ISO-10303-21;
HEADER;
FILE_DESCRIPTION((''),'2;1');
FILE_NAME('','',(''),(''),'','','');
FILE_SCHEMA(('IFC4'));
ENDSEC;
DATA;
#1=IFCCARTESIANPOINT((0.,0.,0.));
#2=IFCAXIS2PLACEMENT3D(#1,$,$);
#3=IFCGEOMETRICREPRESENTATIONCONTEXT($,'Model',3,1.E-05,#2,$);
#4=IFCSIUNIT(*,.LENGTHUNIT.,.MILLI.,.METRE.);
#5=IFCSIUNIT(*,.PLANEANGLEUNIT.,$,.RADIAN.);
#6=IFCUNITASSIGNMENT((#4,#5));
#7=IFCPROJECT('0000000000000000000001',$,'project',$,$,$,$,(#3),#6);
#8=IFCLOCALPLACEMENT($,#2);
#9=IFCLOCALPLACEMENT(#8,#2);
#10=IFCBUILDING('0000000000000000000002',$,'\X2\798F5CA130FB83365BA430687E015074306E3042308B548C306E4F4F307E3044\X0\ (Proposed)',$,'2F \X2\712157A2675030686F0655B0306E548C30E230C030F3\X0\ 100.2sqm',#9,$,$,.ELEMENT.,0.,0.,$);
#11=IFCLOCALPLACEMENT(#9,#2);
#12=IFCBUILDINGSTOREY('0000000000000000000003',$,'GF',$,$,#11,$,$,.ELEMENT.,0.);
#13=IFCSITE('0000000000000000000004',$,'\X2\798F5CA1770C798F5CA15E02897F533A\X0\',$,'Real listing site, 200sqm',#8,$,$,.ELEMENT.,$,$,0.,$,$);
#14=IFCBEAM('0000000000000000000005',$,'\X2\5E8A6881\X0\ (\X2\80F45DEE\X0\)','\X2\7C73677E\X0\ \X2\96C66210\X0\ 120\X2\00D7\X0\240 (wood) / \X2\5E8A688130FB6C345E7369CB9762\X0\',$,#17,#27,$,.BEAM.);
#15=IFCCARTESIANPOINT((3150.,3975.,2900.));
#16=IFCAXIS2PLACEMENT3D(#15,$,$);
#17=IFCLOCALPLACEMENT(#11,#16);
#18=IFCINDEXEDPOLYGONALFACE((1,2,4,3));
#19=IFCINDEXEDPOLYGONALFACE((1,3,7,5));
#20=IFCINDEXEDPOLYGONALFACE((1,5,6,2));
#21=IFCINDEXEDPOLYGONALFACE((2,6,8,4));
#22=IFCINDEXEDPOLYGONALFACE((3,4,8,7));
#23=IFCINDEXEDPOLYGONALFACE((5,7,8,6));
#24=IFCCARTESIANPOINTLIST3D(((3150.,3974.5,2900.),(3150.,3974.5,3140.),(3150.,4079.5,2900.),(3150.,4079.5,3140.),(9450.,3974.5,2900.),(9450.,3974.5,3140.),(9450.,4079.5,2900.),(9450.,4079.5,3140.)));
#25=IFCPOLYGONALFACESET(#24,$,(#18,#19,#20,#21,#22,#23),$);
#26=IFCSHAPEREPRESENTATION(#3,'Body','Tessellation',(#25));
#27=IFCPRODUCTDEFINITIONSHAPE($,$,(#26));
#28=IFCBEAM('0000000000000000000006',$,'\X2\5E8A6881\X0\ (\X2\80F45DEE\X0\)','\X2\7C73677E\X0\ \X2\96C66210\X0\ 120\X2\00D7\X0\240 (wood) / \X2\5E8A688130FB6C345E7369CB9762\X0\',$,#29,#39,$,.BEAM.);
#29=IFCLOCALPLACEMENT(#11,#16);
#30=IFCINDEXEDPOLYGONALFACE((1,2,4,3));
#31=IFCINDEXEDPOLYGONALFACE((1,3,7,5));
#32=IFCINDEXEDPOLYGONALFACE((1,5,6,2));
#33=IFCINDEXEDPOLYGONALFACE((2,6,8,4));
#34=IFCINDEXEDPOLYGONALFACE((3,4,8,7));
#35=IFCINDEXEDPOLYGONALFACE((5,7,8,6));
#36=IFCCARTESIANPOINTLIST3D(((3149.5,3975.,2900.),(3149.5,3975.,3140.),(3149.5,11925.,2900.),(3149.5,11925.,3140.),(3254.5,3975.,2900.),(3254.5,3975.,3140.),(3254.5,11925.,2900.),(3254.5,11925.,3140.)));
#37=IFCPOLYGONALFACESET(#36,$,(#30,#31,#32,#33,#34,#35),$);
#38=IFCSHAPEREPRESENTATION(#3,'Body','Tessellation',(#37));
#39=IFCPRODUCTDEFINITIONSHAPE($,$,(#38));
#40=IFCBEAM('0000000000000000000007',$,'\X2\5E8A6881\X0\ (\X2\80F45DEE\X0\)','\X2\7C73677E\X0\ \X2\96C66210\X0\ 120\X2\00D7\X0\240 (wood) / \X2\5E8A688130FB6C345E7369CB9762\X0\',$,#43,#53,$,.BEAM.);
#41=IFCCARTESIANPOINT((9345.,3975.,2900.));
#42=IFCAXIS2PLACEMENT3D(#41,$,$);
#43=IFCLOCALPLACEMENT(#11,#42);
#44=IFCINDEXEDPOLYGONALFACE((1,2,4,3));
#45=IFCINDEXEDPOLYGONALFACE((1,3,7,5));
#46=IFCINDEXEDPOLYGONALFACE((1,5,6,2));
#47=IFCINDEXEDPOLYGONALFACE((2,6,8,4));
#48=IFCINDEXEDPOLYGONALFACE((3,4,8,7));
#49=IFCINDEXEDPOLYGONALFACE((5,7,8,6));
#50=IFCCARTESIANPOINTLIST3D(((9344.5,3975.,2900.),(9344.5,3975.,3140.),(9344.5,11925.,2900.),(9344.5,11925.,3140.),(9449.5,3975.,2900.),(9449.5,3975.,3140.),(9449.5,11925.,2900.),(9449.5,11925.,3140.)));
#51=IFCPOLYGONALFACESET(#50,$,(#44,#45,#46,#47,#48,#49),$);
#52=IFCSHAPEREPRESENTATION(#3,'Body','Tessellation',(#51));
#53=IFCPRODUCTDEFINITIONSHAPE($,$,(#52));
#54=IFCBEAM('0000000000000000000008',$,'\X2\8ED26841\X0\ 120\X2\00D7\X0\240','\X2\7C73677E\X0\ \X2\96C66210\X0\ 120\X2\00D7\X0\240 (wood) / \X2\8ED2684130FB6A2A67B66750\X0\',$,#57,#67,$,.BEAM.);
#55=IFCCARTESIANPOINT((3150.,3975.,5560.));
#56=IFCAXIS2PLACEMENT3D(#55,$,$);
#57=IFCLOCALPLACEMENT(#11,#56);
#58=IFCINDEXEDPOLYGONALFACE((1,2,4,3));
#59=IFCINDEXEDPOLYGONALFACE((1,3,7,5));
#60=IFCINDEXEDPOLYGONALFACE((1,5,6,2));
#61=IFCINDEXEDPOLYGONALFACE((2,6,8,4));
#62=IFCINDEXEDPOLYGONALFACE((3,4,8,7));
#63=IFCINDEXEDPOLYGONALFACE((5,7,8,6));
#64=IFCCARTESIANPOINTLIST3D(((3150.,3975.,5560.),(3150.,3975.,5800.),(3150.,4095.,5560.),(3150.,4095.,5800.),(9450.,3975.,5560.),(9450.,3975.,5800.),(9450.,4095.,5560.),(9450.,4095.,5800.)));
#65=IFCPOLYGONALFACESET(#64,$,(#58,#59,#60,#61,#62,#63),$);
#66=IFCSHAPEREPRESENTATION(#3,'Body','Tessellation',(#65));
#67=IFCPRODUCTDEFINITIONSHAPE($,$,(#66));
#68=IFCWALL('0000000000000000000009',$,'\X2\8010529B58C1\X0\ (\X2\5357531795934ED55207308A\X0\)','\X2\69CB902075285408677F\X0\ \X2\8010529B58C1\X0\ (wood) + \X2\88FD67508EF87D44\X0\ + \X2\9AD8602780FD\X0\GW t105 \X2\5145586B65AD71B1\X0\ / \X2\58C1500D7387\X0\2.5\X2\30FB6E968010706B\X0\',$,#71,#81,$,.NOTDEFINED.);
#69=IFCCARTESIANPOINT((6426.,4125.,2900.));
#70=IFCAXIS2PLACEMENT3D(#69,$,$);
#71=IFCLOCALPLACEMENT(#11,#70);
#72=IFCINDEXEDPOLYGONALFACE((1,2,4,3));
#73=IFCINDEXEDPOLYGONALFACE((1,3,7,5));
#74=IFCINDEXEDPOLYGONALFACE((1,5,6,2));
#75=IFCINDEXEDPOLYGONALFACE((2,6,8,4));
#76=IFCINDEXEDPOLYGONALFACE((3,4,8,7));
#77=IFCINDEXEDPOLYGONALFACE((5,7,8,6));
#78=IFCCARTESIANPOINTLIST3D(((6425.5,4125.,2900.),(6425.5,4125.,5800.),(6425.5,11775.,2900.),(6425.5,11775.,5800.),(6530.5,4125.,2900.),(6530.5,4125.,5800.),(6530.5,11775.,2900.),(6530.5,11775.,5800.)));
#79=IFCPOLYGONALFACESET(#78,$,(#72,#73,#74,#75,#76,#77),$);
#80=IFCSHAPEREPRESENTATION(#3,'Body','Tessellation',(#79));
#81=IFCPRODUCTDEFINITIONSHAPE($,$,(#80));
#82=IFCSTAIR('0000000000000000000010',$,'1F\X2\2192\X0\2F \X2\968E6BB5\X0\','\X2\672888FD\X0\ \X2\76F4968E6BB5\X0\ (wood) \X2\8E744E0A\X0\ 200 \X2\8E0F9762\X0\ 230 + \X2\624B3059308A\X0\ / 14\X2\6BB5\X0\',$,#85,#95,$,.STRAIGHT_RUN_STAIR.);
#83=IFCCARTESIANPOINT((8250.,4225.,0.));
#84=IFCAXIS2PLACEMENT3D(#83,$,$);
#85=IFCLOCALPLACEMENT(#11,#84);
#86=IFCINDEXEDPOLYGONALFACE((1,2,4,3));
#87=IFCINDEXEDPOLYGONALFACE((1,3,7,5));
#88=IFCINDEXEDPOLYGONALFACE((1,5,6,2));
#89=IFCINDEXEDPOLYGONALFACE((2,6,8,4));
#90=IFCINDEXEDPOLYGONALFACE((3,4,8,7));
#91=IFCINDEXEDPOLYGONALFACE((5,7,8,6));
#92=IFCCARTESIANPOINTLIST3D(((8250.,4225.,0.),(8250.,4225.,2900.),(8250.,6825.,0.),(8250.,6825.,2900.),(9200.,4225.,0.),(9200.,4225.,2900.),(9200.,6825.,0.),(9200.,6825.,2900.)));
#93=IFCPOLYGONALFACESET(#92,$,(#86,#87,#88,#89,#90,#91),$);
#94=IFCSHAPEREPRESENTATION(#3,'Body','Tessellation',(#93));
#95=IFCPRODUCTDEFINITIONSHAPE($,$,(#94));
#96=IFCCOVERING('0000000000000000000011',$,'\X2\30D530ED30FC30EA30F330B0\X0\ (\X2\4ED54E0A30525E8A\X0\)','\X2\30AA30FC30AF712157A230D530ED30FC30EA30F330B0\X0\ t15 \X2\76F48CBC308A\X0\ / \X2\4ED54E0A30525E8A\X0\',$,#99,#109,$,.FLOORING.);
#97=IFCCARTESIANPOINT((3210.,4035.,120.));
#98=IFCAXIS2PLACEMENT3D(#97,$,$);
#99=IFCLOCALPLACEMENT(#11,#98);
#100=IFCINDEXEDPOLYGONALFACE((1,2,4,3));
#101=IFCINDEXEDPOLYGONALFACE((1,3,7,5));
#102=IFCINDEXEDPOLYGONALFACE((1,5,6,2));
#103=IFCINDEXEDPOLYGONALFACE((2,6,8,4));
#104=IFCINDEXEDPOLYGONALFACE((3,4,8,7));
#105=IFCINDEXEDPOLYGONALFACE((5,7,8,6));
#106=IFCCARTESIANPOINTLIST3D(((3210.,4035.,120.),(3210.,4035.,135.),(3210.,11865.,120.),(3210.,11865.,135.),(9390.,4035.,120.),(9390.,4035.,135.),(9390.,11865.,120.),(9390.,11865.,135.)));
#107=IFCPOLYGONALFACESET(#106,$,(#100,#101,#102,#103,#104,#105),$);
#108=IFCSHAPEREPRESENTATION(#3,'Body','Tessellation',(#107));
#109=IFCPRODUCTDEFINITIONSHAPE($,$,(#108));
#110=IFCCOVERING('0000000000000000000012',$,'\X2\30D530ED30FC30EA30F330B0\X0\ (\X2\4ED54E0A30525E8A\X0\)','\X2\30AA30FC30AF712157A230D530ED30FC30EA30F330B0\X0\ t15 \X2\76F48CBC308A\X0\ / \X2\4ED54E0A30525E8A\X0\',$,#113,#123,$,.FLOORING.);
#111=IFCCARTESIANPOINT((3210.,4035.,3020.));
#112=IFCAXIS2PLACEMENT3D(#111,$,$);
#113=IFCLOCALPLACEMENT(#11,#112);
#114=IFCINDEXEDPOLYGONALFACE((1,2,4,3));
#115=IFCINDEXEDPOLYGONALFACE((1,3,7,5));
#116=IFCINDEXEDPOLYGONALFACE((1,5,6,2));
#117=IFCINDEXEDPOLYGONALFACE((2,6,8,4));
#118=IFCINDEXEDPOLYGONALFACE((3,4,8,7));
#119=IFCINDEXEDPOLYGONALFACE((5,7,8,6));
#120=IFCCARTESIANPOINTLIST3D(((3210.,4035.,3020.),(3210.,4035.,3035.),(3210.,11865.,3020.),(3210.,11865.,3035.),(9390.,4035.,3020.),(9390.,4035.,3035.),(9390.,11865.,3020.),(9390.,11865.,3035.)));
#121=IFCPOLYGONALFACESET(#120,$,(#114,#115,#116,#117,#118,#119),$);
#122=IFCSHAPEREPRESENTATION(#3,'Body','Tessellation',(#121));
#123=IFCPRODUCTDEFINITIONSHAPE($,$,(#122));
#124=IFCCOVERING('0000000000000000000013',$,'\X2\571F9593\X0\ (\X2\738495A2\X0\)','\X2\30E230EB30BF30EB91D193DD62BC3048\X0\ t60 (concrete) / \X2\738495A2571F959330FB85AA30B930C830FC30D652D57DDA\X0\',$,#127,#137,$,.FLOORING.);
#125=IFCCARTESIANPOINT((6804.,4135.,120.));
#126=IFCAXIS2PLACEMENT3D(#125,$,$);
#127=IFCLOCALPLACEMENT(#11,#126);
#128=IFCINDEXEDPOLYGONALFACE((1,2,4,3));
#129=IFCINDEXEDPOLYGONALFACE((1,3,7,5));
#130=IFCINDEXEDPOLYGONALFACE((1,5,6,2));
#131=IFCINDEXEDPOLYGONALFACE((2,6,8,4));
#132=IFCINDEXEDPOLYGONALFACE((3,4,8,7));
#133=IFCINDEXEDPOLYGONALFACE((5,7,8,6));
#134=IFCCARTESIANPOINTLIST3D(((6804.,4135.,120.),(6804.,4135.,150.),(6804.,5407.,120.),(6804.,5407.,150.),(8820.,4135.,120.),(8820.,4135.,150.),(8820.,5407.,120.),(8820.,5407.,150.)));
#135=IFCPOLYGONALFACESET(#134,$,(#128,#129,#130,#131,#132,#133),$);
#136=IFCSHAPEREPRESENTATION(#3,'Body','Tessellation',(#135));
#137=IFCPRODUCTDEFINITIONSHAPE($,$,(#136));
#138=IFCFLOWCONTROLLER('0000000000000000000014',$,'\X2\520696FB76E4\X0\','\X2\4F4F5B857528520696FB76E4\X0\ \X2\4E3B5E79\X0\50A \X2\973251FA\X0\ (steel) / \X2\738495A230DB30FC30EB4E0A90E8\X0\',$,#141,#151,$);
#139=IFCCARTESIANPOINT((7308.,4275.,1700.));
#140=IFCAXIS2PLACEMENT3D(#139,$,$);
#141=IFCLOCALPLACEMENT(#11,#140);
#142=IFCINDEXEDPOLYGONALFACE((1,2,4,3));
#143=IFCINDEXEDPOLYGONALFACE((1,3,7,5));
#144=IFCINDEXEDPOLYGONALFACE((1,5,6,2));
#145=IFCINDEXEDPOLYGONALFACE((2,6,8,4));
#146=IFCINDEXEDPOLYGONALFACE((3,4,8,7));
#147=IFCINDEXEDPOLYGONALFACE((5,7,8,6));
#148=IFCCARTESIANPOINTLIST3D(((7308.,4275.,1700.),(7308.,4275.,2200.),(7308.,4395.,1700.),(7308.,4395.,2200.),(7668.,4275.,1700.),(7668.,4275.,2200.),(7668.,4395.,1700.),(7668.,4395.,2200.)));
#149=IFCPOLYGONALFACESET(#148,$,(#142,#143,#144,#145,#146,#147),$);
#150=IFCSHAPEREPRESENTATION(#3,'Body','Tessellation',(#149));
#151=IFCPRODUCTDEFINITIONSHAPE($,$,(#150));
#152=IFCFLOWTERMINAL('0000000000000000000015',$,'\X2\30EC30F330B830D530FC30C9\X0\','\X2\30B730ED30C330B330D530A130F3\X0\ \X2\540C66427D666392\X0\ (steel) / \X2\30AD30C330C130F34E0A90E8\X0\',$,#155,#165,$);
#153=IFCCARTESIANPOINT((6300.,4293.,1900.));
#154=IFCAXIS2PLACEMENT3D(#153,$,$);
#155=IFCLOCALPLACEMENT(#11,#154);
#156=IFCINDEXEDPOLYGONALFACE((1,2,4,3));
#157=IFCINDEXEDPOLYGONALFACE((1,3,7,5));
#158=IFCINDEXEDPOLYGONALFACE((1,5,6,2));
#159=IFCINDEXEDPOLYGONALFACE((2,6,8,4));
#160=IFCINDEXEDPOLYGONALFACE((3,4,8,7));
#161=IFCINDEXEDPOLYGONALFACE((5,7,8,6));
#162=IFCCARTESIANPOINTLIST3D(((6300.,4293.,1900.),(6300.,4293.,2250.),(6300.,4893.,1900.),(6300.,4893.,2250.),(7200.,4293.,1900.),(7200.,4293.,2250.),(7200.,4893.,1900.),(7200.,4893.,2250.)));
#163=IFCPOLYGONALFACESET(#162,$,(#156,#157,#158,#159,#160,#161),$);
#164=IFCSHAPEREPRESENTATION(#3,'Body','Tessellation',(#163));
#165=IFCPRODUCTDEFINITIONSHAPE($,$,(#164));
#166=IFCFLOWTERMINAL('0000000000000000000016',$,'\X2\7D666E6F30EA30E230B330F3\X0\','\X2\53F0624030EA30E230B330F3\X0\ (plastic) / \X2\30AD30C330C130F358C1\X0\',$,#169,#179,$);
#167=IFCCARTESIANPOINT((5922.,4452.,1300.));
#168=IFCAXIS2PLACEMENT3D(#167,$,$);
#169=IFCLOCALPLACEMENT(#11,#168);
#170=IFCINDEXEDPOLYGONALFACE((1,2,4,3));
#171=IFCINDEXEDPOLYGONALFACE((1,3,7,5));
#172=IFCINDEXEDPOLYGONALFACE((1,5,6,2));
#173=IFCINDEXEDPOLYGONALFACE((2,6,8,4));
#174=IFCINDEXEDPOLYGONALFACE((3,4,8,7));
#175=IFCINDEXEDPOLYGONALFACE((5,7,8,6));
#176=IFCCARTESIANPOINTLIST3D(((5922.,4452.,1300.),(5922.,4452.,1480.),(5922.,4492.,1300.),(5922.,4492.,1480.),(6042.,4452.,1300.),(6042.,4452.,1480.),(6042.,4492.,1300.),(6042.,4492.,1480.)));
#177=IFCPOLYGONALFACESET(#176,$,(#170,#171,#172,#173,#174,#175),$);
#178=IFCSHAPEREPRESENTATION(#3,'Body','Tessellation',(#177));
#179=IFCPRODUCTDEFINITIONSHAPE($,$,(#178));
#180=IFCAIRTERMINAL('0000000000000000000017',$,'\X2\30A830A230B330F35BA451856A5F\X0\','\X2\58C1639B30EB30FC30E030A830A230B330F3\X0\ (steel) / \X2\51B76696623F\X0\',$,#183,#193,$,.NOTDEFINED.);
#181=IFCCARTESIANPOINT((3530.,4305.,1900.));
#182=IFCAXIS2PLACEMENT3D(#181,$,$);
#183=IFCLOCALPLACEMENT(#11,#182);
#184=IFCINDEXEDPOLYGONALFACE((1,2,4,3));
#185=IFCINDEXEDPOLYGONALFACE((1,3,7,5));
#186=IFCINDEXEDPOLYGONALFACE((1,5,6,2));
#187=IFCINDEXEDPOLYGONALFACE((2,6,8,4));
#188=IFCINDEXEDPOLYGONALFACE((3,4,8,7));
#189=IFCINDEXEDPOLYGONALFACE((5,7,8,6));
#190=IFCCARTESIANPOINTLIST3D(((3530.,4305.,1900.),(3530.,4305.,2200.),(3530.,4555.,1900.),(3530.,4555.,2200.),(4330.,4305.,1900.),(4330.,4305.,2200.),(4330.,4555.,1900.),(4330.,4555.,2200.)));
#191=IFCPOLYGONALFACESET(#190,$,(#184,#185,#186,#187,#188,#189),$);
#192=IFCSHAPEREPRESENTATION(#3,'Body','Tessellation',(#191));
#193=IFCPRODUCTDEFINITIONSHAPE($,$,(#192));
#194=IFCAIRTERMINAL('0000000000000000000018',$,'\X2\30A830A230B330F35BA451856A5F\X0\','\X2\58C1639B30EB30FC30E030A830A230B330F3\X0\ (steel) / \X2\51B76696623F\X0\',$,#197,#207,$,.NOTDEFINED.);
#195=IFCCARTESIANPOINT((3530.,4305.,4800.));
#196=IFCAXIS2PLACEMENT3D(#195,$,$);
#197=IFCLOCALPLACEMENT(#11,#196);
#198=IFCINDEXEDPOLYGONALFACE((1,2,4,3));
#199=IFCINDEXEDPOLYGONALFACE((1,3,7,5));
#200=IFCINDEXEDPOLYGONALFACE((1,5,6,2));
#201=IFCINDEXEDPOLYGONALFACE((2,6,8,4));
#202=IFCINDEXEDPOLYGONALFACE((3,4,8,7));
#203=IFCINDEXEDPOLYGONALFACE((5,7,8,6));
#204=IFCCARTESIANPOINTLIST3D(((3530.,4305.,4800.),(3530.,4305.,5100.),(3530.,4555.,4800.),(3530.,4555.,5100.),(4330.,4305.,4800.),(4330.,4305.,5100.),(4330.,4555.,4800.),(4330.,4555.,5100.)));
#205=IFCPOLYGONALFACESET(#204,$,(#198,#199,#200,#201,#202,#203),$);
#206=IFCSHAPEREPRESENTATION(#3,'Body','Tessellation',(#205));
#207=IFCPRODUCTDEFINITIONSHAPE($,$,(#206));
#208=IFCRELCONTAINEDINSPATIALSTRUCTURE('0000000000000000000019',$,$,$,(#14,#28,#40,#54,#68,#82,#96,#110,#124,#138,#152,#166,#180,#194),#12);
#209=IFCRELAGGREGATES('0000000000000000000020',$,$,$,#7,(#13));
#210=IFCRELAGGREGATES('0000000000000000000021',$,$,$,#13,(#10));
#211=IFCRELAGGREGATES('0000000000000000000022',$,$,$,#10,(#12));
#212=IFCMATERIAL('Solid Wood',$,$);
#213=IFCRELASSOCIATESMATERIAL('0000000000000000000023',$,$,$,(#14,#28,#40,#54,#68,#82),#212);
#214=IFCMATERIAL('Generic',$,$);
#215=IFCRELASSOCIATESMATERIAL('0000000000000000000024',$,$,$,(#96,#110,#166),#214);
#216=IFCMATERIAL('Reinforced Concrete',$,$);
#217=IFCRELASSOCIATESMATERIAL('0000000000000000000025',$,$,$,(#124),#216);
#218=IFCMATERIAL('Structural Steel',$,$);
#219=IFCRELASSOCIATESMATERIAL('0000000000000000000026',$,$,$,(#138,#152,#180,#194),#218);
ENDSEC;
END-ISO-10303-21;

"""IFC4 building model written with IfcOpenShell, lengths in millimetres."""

from ifc_helpers import new_model, si_unit, frame, frame_2d, origin, place, context, project, spatial, rectangle, extrude, material, element, save


model = new_model("IFC4")

# Units and contexts
model_context = context("Model", 3, precision=1e-05, world=origin())
ifc_project = project(units=[si_unit("LENGTHUNIT", "METRE", prefix="MILLI"), si_unit("PLANEANGLEUNIT", "RADIAN")], contexts=[model_context])

# Site, building, storey
site_placement = place(None, origin())
site = spatial("IfcSite", under=ifc_project, at=site_placement, Name="福岡県福岡市西区", ObjectType="Real listing site, 200sqm", CompositionType="ELEMENT", RefElevation=0.0)
building_placement = place(site_placement, origin())
building = spatial("IfcBuilding", under=site, at=building_placement, Name="福岡・茶室と縁側のある和の住まい (Proposed)", ObjectType="2F 無垢材と漆喰の和モダン 100.2sqm", CompositionType="ELEMENT", ElevationOfRefHeight=0.0, ElevationOfTerrain=0.0)
storey_placement = place(building_placement, origin())
storey = spatial("IfcBuildingStorey", under=building, at=storey_placement, Name="GF", CompositionType="ELEMENT", Elevation=0.0)

# Shared definitions
ifc_material_1 = material(Name="Solid Wood")

# Beams
beam_1_placement = place(storey_placement, frame((3150.0, 3975.0, 2900.0)))
element("IfcBeam", 1, at=beam_1_placement, inside=storey, material=ifc_material_1, Name="床梁 (胴差)", Description="米松 集成 120×240 (wood) / 床梁・水平構面", PredefinedType="BEAM", context=model_context, shape_type="SweptSolid", body=[
    extrude(rectangle(XDim=6300.0, YDim=105.0, at=frame_2d((3150.0, 52.0))), frame((3150.0, 3975.0, 2900.0)), (0.0, 0.0, 1.0), 240.0),
])
beam_2_placement = place(storey_placement, frame((3150.0, 3975.0, 2900.0)))
element("IfcBeam", 2, at=beam_2_placement, inside=storey, material=ifc_material_1, Name="床梁 (胴差)", Description="米松 集成 120×240 (wood) / 床梁・水平構面", PredefinedType="BEAM", context=model_context, shape_type="SweptSolid", body=[
    extrude(rectangle(XDim=105.0, YDim=7950.0, at=frame_2d((52.0, 3975.0))), frame((3150.0, 3975.0, 2900.0)), (0.0, 0.0, 1.0), 240.0),
])
beam_3_placement = place(storey_placement, frame((9345.0, 3975.0, 2900.0)))
element("IfcBeam", 3, at=beam_3_placement, inside=storey, material=ifc_material_1, Name="床梁 (胴差)", Description="米松 集成 120×240 (wood) / 床梁・水平構面", PredefinedType="BEAM", context=model_context, shape_type="SweptSolid", body=[
    extrude(rectangle(XDim=105.0, YDim=7950.0, at=frame_2d((52.0, 3975.0))), frame((9345.0, 3975.0, 2900.0)), (0.0, 0.0, 1.0), 240.0),
])
beam_4_placement = place(storey_placement, frame((3150.0, 3975.0, 5560.0)))
element("IfcBeam", 4, at=beam_4_placement, inside=storey, material=ifc_material_1, Name="軒桁 120×240", Description="米松 集成 120×240 (wood) / 軒桁・横架材", PredefinedType="BEAM", context=model_context, shape_type="SweptSolid", body=[
    extrude(rectangle(XDim=6300.0, YDim=120.0, at=frame_2d((3150.0, 60.0))), frame((3150.0, 3975.0, 5560.0)), (0.0, 0.0, 1.0), 240.0),
])

# Wall
wall_1_placement = place(storey_placement, frame((6426.0, 4125.0, 2900.0)))
element("IfcWall", 5, at=wall_1_placement, inside=storey, material=ifc_material_1, Name="耐力壁 (南北間仕切り)", Description="構造用合板 耐力壁 (wood) + 製材軸組 + 高性能GW t105 充填断熱 / 壁倍率2.5・準耐火", PredefinedType="NOTDEFINED", context=model_context, shape_type="SweptSolid", body=[
    extrude(rectangle(XDim=105.0, YDim=7650.0, at=frame_2d((52.0, 3825.0))), frame((6426.0, 4125.0, 2900.0)), (0.0, 0.0, 1.0), 2900.0),
])

# Stair
stair_placement = place(storey_placement, frame((8250.0, 4225.0, 0.0)))
element("IfcStair", 6, at=stair_placement, inside=storey, material=ifc_material_1, Name="1F→2F 階段", Description="木製 直階段 (wood) 蹴上 200 踏面 230 + 手すり / 14段", PredefinedType="STRAIGHT_RUN_STAIR", context=model_context, shape_type="SweptSolid", body=[
    extrude(rectangle(XDim=950.0, YDim=2600.0, at=frame_2d((475.0, 1300.0))), frame((8250.0, 4225.0, 0.0)), (0.0, 0.0, 1.0), 2900.0),
])

# Coverings
ifc_material_2 = material(Name="Generic")
covering_1_placement = place(storey_placement, frame((3210.0, 4035.0, 120.0)))
element("IfcCovering", 7, at=covering_1_placement, inside=storey, material=ifc_material_2, Name="フローリング (仕上げ床)", Description="オーク無垢フローリング t15 直貼り / 仕上げ床", PredefinedType="FLOORING", context=model_context, shape_type="SweptSolid", body=[
    extrude(rectangle(XDim=6180.0, YDim=7830.0, at=frame_2d((3090.0, 3915.0))), frame((3210.0, 4035.0, 120.0)), (0.0, 0.0, 1.0), 15.0),
])
covering_2_placement = place(storey_placement, frame((3210.0, 4035.0, 3020.0)))
element("IfcCovering", 8, at=covering_2_placement, inside=storey, material=ifc_material_2, Name="フローリング (仕上げ床)", Description="オーク無垢フローリング t15 直貼り / 仕上げ床", PredefinedType="FLOORING", context=model_context, shape_type="SweptSolid", body=[
    extrude(rectangle(XDim=6180.0, YDim=7830.0, at=frame_2d((3090.0, 3915.0))), frame((3210.0, 4035.0, 3020.0)), (0.0, 0.0, 1.0), 15.0),
])
ifc_material_3 = material(Name="Reinforced Concrete")
covering_3_placement = place(storey_placement, frame((6804.0, 4135.0, 120.0)))
element("IfcCovering", 9, at=covering_3_placement, inside=storey, material=ifc_material_3, Name="土間 (玄関)", Description="モルタル金鏝押え t60 (concrete) / 玄関土間・薪ストーブ動線", PredefinedType="FLOORING", context=model_context, shape_type="SweptSolid", body=[
    extrude(rectangle(XDim=2016.0, YDim=1272.0, at=frame_2d((1008.0, 636.0))), frame((6804.0, 4135.0, 120.0)), (0.0, 0.0, 1.0), 30.0),
])

# Flow controller
ifc_material_4 = material(Name="Structural Steel")
flow_controller_placement = place(storey_placement, frame((7308.0, 4275.0, 1700.0)))
element("IfcFlowController", 10, at=flow_controller_placement, inside=storey, material=ifc_material_4, Name="分電盤", Description="住宅用分電盤 主幹50A 露出 (steel) / 玄関ホール上部", context=model_context, shape_type="SweptSolid", body=[
    extrude(rectangle(XDim=360.0, YDim=120.0, at=frame_2d((180.0, 60.0))), frame((7308.0, 4275.0, 1700.0)), (0.0, 0.0, 1.0), 500.0),
])

# Flow terminals
flow_terminal_1_placement = place(storey_placement, frame((6300.0, 4293.0, 1900.0)))
element("IfcFlowTerminal", 11, at=flow_terminal_1_placement, inside=storey, material=ifc_material_4, Name="レンジフード", Description="シロッコファン 同時給排 (steel) / キッチン上部", context=model_context, shape_type="SweptSolid", body=[
    extrude(rectangle(XDim=900.0, YDim=600.0, at=frame_2d((450.0, 300.0))), frame((6300.0, 4293.0, 1900.0)), (0.0, 0.0, 1.0), 350.0),
])
flow_terminal_2_placement = place(storey_placement, frame((5922.0, 4452.0, 1300.0)))
element("IfcFlowTerminal", 12, at=flow_terminal_2_placement, inside=storey, material=ifc_material_2, Name="給湯リモコン", Description="台所リモコン (plastic) / キッチン壁", context=model_context, shape_type="SweptSolid", body=[
    extrude(rectangle(XDim=120.0, YDim=40.0, at=frame_2d((60.0, 20.0))), frame((5922.0, 4452.0, 1300.0)), (0.0, 0.0, 1.0), 180.0),
])

# Air terminals
air_terminal_1_placement = place(storey_placement, frame((3530.0, 4305.0, 1900.0)))
element("IfcAirTerminal", 13, at=air_terminal_1_placement, inside=storey, material=ifc_material_4, Name="エアコン室内機", Description="壁掛ルームエアコン (steel) / 冷暖房", PredefinedType="NOTDEFINED", context=model_context, shape_type="SweptSolid", body=[
    extrude(rectangle(XDim=800.0, YDim=250.0, at=frame_2d((400.0, 125.0))), frame((3530.0, 4305.0, 1900.0)), (0.0, 0.0, 1.0), 300.0),
])
air_terminal_2_placement = place(storey_placement, frame((3530.0, 4305.0, 4800.0)))
element("IfcAirTerminal", 14, at=air_terminal_2_placement, inside=storey, material=ifc_material_4, Name="エアコン室内機", Description="壁掛ルームエアコン (steel) / 冷暖房", PredefinedType="NOTDEFINED", context=model_context, shape_type="SweptSolid", body=[
    extrude(rectangle(XDim=800.0, YDim=250.0, at=frame_2d((400.0, 125.0))), frame((3530.0, 4305.0, 4800.0)), (0.0, 0.0, 1.0), 300.0),
])

save(model, "model.ifc")
